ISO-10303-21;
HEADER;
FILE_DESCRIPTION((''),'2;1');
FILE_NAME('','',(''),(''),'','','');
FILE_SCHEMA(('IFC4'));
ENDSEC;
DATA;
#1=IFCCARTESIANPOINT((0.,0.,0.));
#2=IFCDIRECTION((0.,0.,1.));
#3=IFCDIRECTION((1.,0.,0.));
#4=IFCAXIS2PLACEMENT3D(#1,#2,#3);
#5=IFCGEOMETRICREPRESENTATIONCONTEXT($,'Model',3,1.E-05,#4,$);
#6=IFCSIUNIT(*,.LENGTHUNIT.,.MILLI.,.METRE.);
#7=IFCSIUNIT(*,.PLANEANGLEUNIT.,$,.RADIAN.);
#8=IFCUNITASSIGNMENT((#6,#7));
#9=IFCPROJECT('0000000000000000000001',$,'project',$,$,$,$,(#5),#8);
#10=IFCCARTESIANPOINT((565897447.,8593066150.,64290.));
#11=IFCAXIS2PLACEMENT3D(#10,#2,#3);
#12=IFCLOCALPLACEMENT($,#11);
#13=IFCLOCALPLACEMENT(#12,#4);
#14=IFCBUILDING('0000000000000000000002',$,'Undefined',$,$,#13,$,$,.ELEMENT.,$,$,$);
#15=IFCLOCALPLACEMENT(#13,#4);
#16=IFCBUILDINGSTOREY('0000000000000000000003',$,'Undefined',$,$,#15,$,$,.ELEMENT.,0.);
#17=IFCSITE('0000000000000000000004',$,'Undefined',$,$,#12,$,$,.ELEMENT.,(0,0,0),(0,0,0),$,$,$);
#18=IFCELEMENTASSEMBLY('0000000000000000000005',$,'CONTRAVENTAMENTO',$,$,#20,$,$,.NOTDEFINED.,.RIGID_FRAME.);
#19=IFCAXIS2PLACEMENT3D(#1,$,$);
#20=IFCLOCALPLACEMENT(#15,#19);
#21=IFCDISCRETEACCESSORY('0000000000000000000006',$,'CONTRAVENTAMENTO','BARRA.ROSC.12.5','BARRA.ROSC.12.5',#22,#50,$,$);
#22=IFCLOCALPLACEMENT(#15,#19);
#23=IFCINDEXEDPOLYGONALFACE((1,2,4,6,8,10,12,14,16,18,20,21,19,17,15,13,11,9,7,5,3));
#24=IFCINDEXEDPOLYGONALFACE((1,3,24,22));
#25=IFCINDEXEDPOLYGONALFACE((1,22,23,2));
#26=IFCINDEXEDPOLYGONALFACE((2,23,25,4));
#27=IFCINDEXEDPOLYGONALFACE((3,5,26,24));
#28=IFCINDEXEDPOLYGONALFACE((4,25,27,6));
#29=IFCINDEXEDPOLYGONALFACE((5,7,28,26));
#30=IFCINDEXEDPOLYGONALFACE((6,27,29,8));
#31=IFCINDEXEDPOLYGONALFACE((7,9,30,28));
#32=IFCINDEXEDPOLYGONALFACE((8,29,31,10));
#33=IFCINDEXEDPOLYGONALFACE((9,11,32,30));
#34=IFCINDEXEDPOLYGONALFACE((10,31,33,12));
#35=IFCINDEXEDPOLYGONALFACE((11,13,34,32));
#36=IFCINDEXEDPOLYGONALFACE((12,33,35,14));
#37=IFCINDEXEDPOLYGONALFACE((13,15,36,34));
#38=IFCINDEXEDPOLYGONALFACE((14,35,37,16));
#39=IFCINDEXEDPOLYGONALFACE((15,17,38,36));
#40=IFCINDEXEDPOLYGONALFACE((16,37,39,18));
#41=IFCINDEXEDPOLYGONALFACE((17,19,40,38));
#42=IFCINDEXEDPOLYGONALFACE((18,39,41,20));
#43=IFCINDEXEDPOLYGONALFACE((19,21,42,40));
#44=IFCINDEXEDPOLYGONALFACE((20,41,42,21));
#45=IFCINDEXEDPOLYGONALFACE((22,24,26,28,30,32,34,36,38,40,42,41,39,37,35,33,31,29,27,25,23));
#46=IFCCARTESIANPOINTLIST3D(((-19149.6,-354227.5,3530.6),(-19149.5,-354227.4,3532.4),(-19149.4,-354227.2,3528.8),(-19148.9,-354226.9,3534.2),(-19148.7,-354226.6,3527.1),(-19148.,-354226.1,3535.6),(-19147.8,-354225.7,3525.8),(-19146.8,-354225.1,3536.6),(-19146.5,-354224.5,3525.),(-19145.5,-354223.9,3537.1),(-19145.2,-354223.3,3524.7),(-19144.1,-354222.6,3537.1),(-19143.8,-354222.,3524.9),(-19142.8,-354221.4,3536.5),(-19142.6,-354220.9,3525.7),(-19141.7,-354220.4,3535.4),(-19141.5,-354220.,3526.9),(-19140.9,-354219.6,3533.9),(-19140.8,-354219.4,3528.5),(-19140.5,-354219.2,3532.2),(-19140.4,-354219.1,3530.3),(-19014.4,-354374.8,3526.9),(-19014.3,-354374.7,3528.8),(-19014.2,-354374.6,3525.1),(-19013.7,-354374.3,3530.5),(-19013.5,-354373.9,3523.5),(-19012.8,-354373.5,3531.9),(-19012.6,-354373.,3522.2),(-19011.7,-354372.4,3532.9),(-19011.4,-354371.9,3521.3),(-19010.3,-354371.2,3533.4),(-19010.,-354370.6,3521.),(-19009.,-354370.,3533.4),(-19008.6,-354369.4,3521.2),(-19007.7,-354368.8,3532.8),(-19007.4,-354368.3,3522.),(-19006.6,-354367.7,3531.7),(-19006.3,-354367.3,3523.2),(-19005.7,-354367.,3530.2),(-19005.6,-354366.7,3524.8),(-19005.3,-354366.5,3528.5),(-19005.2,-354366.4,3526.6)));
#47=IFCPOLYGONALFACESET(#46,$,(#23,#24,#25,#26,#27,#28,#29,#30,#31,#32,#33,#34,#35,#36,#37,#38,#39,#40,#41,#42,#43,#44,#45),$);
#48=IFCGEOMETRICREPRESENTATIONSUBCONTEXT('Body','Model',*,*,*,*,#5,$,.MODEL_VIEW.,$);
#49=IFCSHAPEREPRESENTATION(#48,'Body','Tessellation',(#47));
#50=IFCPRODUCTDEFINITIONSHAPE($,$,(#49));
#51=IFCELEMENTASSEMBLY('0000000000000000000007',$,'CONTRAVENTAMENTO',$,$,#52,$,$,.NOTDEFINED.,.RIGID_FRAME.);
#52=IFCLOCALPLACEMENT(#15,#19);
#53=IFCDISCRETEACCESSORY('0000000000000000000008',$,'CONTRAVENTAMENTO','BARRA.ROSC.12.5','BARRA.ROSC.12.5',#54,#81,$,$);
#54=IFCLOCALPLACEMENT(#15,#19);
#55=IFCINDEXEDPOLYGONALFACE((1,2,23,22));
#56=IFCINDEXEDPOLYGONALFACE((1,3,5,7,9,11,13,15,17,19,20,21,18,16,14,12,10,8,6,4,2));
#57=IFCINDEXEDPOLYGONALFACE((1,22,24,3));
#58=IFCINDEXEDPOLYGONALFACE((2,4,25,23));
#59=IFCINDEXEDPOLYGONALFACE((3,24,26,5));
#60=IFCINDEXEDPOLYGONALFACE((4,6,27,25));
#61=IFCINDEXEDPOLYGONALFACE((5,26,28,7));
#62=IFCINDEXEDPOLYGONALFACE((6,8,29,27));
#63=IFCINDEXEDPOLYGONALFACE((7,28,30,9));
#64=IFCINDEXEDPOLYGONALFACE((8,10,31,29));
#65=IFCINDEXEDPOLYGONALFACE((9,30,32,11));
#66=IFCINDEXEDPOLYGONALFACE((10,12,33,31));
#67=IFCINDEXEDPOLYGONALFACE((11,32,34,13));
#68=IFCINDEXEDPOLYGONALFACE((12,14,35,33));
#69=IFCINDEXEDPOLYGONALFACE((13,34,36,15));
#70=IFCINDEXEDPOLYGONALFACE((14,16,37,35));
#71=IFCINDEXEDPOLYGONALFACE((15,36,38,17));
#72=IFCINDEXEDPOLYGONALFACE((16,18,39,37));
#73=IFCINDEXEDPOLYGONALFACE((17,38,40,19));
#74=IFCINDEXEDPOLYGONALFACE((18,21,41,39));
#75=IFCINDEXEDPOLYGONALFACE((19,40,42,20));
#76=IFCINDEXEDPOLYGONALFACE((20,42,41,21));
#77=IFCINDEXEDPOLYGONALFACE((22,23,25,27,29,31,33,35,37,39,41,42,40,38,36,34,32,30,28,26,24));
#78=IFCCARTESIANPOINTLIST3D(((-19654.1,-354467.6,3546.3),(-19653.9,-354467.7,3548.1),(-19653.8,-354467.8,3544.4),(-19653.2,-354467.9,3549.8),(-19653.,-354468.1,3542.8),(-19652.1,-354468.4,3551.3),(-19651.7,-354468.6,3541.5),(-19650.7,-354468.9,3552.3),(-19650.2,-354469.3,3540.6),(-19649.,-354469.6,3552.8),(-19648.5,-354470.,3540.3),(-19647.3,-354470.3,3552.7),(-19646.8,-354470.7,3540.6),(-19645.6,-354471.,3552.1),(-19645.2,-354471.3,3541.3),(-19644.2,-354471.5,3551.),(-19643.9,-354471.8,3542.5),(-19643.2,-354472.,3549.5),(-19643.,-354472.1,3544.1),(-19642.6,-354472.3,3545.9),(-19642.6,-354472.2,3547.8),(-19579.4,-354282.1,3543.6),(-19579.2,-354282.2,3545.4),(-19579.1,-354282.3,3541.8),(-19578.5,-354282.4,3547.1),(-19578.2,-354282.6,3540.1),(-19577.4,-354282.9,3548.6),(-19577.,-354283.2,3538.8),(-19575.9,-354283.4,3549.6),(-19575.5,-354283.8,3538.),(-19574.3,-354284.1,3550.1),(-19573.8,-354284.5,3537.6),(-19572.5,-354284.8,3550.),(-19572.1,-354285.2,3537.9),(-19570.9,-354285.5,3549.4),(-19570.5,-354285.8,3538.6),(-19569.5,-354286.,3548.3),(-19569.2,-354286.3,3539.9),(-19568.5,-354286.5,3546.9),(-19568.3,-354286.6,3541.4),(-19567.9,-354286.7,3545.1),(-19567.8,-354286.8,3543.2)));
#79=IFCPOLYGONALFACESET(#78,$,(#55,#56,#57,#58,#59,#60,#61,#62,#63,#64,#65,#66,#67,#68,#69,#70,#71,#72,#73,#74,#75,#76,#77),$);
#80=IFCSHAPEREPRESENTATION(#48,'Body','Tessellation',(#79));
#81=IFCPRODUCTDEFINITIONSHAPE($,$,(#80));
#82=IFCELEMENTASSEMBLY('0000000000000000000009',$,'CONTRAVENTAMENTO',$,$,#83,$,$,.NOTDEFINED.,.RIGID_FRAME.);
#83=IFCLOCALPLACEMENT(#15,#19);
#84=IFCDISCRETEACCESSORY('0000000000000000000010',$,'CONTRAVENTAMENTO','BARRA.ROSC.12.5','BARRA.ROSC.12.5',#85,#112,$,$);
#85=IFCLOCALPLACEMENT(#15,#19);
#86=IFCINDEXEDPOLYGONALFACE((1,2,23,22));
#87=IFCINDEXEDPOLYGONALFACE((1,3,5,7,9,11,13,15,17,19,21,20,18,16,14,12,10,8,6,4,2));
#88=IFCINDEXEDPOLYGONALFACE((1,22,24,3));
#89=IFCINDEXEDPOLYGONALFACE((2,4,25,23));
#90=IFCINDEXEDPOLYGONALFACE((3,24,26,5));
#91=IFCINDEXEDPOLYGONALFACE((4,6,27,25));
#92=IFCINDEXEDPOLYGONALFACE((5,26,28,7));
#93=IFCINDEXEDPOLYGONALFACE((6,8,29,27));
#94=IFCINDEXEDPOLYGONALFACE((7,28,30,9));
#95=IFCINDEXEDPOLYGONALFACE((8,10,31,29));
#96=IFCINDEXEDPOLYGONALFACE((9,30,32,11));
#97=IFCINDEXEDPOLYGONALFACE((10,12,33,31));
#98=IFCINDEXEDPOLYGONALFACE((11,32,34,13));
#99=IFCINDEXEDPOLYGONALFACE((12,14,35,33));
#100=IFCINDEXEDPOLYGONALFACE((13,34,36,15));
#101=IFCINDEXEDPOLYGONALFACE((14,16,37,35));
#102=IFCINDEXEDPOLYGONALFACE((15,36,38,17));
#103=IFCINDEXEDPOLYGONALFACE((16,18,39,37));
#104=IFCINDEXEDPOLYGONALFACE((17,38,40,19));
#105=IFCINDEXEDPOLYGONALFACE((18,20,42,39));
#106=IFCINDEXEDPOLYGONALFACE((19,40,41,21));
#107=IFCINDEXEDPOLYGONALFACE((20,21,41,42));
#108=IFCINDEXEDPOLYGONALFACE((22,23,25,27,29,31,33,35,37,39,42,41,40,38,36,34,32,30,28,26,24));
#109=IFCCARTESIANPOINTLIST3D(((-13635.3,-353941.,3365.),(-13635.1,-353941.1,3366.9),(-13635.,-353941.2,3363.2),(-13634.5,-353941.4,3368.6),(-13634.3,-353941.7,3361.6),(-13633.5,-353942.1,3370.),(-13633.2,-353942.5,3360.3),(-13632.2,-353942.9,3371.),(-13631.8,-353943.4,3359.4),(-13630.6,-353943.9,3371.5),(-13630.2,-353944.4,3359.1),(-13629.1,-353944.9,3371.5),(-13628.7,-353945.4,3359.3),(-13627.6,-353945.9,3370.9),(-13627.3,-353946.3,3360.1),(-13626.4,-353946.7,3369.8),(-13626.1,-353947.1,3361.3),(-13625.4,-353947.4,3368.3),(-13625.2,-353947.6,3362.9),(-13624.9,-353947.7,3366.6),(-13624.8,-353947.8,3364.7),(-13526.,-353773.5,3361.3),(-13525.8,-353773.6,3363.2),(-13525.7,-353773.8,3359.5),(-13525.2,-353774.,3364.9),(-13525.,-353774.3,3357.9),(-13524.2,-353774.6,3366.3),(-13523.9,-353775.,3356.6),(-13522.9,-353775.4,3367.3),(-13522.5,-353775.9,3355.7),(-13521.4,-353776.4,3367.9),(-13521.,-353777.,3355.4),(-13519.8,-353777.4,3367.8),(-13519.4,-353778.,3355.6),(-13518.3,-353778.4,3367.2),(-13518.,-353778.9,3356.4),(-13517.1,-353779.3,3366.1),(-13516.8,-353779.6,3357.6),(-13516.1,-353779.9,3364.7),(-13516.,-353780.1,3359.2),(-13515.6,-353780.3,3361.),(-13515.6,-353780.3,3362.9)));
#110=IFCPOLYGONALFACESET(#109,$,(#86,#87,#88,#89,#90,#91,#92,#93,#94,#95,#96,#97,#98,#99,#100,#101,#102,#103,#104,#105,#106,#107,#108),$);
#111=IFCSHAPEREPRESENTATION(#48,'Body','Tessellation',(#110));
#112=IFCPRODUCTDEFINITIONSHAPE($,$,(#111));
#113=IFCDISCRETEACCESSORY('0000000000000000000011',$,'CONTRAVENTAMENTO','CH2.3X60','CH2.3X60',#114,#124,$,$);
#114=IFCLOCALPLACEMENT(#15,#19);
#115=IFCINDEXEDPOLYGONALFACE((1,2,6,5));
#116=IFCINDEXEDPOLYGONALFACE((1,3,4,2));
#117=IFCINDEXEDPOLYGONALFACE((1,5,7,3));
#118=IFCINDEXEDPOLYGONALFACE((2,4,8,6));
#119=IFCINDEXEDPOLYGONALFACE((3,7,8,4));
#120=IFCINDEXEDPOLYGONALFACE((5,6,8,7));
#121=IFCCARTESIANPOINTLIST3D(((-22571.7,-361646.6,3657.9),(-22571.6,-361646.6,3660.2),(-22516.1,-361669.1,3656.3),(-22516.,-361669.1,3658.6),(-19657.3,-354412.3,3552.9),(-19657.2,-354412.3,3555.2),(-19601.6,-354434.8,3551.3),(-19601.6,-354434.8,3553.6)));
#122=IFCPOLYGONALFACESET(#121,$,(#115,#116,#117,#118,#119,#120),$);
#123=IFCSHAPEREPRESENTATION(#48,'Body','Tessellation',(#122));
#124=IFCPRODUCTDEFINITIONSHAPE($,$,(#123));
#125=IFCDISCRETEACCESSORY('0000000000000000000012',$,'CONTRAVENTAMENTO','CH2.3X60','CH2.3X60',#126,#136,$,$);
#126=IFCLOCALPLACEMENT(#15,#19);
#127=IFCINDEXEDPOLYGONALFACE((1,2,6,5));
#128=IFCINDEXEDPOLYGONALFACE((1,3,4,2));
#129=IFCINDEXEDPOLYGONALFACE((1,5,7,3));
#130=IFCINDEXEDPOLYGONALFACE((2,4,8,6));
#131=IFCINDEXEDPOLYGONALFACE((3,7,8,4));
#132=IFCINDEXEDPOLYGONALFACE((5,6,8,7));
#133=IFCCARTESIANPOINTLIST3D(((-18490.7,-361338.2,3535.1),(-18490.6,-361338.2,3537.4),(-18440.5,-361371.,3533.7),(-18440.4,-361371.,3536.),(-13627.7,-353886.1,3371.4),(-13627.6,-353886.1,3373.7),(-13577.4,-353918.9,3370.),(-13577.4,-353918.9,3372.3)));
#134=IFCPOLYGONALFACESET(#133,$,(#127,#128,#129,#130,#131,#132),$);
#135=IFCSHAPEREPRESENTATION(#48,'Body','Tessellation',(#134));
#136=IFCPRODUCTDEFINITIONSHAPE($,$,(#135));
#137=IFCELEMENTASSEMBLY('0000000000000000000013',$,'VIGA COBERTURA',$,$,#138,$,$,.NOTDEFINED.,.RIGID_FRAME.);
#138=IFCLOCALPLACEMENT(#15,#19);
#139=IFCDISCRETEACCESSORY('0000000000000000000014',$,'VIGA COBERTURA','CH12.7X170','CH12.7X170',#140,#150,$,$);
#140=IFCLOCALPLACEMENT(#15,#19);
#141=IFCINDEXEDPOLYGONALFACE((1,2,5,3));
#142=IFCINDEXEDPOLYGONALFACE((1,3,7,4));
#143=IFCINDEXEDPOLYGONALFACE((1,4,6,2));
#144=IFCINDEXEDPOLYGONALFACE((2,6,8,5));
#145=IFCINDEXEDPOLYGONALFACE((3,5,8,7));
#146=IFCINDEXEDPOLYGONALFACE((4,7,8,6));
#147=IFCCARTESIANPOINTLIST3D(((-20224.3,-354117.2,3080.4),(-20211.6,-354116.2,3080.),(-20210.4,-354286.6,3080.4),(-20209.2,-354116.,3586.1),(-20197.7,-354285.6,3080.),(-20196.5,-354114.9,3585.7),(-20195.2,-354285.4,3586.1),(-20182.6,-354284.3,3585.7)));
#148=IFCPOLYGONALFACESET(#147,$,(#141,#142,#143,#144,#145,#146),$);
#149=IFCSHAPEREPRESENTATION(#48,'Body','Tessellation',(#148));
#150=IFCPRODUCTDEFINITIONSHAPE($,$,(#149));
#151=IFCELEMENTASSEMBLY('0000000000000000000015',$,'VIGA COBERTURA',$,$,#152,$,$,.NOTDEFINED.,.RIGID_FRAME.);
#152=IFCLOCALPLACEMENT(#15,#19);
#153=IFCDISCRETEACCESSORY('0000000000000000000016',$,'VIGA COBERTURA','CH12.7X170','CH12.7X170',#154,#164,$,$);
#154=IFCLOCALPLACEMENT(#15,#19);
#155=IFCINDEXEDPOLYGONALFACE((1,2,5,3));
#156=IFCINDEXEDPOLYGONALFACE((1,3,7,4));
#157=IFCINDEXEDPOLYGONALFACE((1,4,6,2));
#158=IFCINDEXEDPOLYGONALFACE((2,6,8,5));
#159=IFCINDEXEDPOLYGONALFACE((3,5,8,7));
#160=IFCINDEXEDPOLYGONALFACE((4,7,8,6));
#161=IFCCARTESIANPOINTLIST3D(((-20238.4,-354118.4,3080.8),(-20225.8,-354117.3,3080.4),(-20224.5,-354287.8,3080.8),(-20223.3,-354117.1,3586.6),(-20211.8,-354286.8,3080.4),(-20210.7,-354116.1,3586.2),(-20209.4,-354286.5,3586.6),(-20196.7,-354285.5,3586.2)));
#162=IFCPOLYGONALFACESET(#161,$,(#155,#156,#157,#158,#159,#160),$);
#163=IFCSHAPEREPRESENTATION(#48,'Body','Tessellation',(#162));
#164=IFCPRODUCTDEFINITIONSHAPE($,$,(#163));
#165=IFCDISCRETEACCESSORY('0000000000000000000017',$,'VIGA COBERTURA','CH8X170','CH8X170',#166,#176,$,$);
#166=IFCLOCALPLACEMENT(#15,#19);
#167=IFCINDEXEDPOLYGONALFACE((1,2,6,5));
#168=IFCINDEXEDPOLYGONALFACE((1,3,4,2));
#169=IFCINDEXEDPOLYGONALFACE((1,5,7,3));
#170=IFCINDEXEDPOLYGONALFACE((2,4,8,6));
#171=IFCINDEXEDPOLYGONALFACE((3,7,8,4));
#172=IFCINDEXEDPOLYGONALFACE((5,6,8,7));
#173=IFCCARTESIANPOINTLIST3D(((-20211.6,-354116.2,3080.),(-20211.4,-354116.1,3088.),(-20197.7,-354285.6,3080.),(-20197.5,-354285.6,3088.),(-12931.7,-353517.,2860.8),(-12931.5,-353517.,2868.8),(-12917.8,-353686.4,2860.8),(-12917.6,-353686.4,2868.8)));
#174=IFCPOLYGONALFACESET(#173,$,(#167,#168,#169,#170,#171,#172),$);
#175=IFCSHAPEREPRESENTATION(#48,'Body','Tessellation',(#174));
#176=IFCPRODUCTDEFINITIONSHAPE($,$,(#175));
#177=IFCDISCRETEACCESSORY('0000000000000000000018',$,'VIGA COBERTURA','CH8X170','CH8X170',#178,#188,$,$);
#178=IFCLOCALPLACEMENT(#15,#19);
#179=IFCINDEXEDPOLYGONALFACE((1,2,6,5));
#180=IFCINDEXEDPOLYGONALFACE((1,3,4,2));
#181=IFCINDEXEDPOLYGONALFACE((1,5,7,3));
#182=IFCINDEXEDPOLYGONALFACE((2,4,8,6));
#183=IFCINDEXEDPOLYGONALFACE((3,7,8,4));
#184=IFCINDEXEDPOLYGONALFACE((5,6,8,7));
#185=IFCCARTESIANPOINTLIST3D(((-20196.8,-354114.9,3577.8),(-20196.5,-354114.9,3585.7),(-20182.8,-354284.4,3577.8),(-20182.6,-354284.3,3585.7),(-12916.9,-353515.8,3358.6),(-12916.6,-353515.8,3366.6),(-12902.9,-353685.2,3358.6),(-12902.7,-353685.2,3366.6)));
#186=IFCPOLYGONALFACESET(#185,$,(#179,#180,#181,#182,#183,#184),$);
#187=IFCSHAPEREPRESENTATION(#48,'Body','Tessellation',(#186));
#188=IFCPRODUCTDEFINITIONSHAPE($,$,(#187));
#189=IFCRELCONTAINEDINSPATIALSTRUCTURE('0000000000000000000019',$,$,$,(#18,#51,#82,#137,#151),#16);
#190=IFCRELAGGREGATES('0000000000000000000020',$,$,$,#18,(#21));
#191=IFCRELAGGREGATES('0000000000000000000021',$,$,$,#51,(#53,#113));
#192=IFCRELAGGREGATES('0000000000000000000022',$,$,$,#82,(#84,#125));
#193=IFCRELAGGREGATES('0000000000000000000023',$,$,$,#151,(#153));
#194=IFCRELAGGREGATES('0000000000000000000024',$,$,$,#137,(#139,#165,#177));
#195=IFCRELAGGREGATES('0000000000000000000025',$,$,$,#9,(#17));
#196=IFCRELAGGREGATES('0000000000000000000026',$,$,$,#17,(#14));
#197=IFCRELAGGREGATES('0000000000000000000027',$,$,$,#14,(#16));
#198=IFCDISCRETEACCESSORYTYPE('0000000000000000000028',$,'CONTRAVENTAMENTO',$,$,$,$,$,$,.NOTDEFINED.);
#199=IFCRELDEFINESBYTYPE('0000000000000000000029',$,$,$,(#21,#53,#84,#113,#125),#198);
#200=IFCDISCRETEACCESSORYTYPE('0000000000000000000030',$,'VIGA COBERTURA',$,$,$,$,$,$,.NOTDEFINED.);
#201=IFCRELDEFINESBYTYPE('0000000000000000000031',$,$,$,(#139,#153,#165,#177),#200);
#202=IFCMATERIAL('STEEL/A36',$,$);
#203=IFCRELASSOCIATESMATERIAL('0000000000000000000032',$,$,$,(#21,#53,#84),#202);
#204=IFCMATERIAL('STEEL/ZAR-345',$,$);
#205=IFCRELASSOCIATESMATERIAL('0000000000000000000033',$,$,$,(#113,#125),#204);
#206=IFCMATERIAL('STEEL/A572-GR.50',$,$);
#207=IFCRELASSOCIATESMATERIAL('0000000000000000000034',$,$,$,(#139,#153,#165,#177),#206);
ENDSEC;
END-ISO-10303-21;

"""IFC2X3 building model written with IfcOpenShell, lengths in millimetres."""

from ifc_helpers import new_model, si_unit, frame, origin_with_axes, origin_2d_with_axis, place, context, subcontext, project, spatial, polyline, rectangle, circle, outline, extrude, material, type_object, element, aggregate, save


model = new_model("IFC2X3")

# Units and contexts
model_context = context("Model", 3, precision=1e-05, world=origin_with_axes())
body_context = subcontext(model_context, "Body", "Model", "MODEL_VIEW")
ifc_project = project(units=[si_unit("LENGTHUNIT", "METRE", prefix="MILLI"), si_unit("PLANEANGLEUNIT", "RADIAN")], contexts=[model_context])

# Site, building, storey
site_placement = place(None, frame((565897447.0, 8593066150.0, 64290.0), z_axis=(0.0, 0.0, 1.0), x_axis=(1.0, 0.0, 0.0)))
site = spatial("IfcSite", under=ifc_project, at=site_placement, Name="Undefined", CompositionType="ELEMENT", RefLatitude=(0, 0, 0), RefLongitude=(0, 0, 0))
building_placement = place(site_placement, origin_with_axes())
building = spatial("IfcBuilding", under=site, at=building_placement, Name="Undefined", CompositionType="ELEMENT")
storey_placement = place(building_placement, origin_with_axes())
storey = spatial("IfcBuildingStorey", under=building, at=storey_placement, Name="Undefined", CompositionType="ELEMENT", Elevation=0.0)

# Shared definitions
ifc_material_1 = material(Name="STEEL/A36")

# Element assemblies, discrete accessories
assembly_1_placement = place(storey_placement, origin_with_axes())
assembly_1 = element("IfcElementAssembly", 1, at=assembly_1_placement, inside=storey, Name="CONTRAVENTAMENTO", AssemblyPlace="NOTDEFINED", PredefinedType="RIGID_FRAME")
discrete_accessory_type_1 = type_object("IfcDiscreteAccessoryType", Name="CONTRAVENTAMENTO")
discrete_accessory_1_placement = place(assembly_1_placement, frame((-19145.0, -354223.3, 3530.9), z_axis=(-0.736334, -0.676203, 0.02368), x_axis=(0.675958, -0.736711, -0.018398)))
discrete_accessory_1 = element("IfcDiscreteAccessory", 2, at=discrete_accessory_1_placement, type_object=discrete_accessory_type_1, material=ifc_material_1, Name="CONTRAVENTAMENTO", Description="BARRA.ROSC.12.5", ObjectType="BARRA.ROSC.12.5", context=body_context, shape_type="SweptSolid", body=[
    extrude(circle(Radius=6.2, at=origin_2d_with_axis()), frame((200.0, 0.0, 0.0), z_axis=(-1.0, 0.0, 0.0), x_axis=(0.0, -1.0, 0.0)), (0.0, 0.0, 1.0), 200.0),
])
aggregate(assembly_1, [discrete_accessory_1])
assembly_2_placement = place(storey_placement, origin_with_axes())
assembly_2 = element("IfcElementAssembly", 3, at=assembly_2_placement, inside=storey, Name="CONTRAVENTAMENTO", AssemblyPlace="NOTDEFINED", PredefinedType="RIGID_FRAME")
discrete_accessory_2_placement = place(assembly_2_placement, frame((-19573.6, -354284.5, 3543.9), z_axis=(-0.92709, 0.373879, 0.026799), x_axis=(-0.373645, -0.927474, 0.013454)))
discrete_accessory_2 = element("IfcDiscreteAccessory", 4, at=discrete_accessory_2_placement, type_object=discrete_accessory_type_1, material=ifc_material_1, Name="CONTRAVENTAMENTO", Description="BARRA.ROSC.12.5", ObjectType="BARRA.ROSC.12.5", context=body_context, shape_type="SweptSolid", body=[
    extrude(circle(Radius=6.2, at=origin_2d_with_axis()), frame((200.0, 0.0, 0.0), z_axis=(-1.0, 0.0, 0.0), x_axis=(0.0, -1.0, 0.0)), (0.0, 0.0, 1.0), 200.0),
])
assembly_3_placement = place(storey_placement, origin_with_axes())
assembly_3 = element("IfcElementAssembly", 5, at=assembly_3_placement, inside=storey, Name="CONTRAVENTAMENTO", AssemblyPlace="NOTDEFINED", PredefinedType="RIGID_FRAME")
discrete_accessory_3_placement = place(assembly_3_placement, frame((-13520.8, -353776.9, 3361.7), z_axis=(-0.836984, 0.546715, 0.02368), x_axis=(-0.546411, -0.837315, 0.018398)))
discrete_accessory_3 = element("IfcDiscreteAccessory", 6, at=discrete_accessory_3_placement, type_object=discrete_accessory_type_1, material=ifc_material_1, Name="CONTRAVENTAMENTO", Description="BARRA.ROSC.12.5", ObjectType="BARRA.ROSC.12.5", context=body_context, shape_type="SweptSolid", body=[
    extrude(circle(Radius=6.2, at=origin_2d_with_axis()), frame((200.0, 0.0, 0.0), z_axis=(-1.0, 0.0, 0.0), x_axis=(0.0, -1.0, 0.0)), (0.0, 0.0, 1.0), 200.0),
])

# Discrete accessories
ifc_material_2 = material(Name="STEEL/ZAR-345")
discrete_accessory_4_placement = place(assembly_2_placement, frame((-19629.4, -354423.6, 3553.3), z_axis=(-0.029885, -0.00246, -0.99955), x_axis=(-0.373645, -0.927474, 0.013454)))
discrete_accessory_4 = element("IfcDiscreteAccessory", 7, at=discrete_accessory_4_placement, type_object=discrete_accessory_type_1, material=ifc_material_2, Name="CONTRAVENTAMENTO", Description="CH2.3X60", ObjectType="CH2.3X60", context=body_context, shape_type="SweptSolid", body=[
    extrude(outline(polyline([(0.0, 30.0), (7800.0, 30.0), (7800.0, -30.0), (0.0, -30.0), (0.0, 30.0)])), frame((0.0, 0.0, -1.1), z_axis=(0.0, 0.0, 1.0), x_axis=(1.0, 0.0, 0.0)), (0.0, 0.0, 1.0), 2.3),
])
aggregate(assembly_2, [discrete_accessory_2, discrete_accessory_4])
discrete_accessory_5_placement = place(assembly_3_placement, frame((-13602.5, -353902.5, 3371.8), z_axis=(-0.029885, -0.00246, -0.99955), x_axis=(-0.546411, -0.837315, 0.018398)))
discrete_accessory_5 = element("IfcDiscreteAccessory", 8, at=discrete_accessory_5_placement, type_object=discrete_accessory_type_1, material=ifc_material_2, Name="CONTRAVENTAMENTO", Description="CH2.3X60", ObjectType="CH2.3X60", context=body_context, shape_type="SweptSolid", body=[
    extrude(outline(polyline([(0.0, 30.0), (8900.0, 30.0), (8900.0, -30.0), (0.0, -30.0), (0.0, 30.0)])), frame((0.0, 0.0, -1.1), z_axis=(0.0, 0.0, 1.0), x_axis=(1.0, 0.0, 0.0)), (0.0, 0.0, 1.0), 2.3),
])
aggregate(assembly_3, [discrete_accessory_3, discrete_accessory_5])

# Element assemblies, discrete accessories
assembly_4_placement = place(storey_placement, origin_with_axes())
assembly_4 = element("IfcElementAssembly", 9, at=assembly_4_placement, inside=storey, Name="VIGA COBERTURA", AssemblyPlace="NOTDEFINED", PredefinedType="RIGID_FRAME")
ifc_material_3 = material(Name="STEEL/A572-GR.50")
discrete_accessory_type_2 = type_object("IfcDiscreteAccessoryType", Name="VIGA COBERTURA")
discrete_accessory_6_placement = place(assembly_4_placement, frame((-20195.9, -354200.1, 3585.9), z_axis=(-0.082025, 0.99663, 0.0), x_axis=(-0.029885, -0.00246, -0.99955)))
discrete_accessory_6 = element("IfcDiscreteAccessory", 10, at=discrete_accessory_6_placement, type_object=discrete_accessory_type_2, material=ifc_material_3, Name="VIGA COBERTURA", Description="CH12.7X170", ObjectType="CH12.7X170", context=body_context, shape_type="SweptSolid", body=[
    extrude(rectangle(XDim=12.7, YDim=170.0, at=origin_2d_with_axis()), frame((506.0, 0.0, 0.0), z_axis=(-1.0, 0.0, 0.0), x_axis=(0.0, -1.0, 0.0)), (0.0, 0.0, 1.0), 506.0),
])
assembly_5_placement = place(storey_placement, origin_with_axes())
assembly_5 = element("IfcElementAssembly", 11, at=assembly_5_placement, inside=storey, Name="VIGA COBERTURA", AssemblyPlace="NOTDEFINED", PredefinedType="RIGID_FRAME")
discrete_accessory_7_placement = place(assembly_5_placement, frame((-20210.0, -354201.3, 3586.4), z_axis=(-0.082025, 0.99663, 0.0), x_axis=(-0.029885, -0.00246, -0.99955)))
discrete_accessory_7 = element("IfcDiscreteAccessory", 12, at=discrete_accessory_7_placement, type_object=discrete_accessory_type_2, material=ifc_material_3, Name="VIGA COBERTURA", Description="CH12.7X170", ObjectType="CH12.7X170", context=body_context, shape_type="SweptSolid", body=[
    extrude(rectangle(XDim=12.7, YDim=170.0, at=origin_2d_with_axis()), frame((506.0, 0.0, 0.0), z_axis=(-1.0, 0.0, 0.0), x_axis=(0.0, -1.0, 0.0)), (0.0, 0.0, 1.0), 506.0),
])

# Discrete accessories
discrete_accessory_8_placement = place(assembly_4_placement, frame((-20204.6, -354200.9, 3084.0), z_axis=(-0.029885, -0.00246, -0.99955), x_axis=(0.996182, 0.081989, -0.029987)))
discrete_accessory_8 = element("IfcDiscreteAccessory", 13, at=discrete_accessory_8_placement, type_object=discrete_accessory_type_2, material=ifc_material_3, Name="VIGA COBERTURA", Description="CH8X170", ObjectType="CH8X170", context=body_context, shape_type="SweptSolid", body=[
    extrude(outline(polyline([(0.0, -85.0), (0.0, 85.0), (7307.8, 85.0), (7307.8, -85.0), (0.0, -85.0)])), frame((0.0, 0.0, -4.0), z_axis=(0.0, 0.0, 1.0), x_axis=(1.0, 0.0, 0.0)), (0.0, 0.0, 1.0), 8.0),
])
aggregate(assembly_5, [discrete_accessory_7])
discrete_accessory_9_placement = place(assembly_4_placement, frame((-20189.7, -354199.6, 3581.7), z_axis=(-0.029885, -0.00246, -0.99955), x_axis=(0.996182, 0.081989, -0.029987)))
discrete_accessory_9 = element("IfcDiscreteAccessory", 14, at=discrete_accessory_9_placement, type_object=discrete_accessory_type_2, material=ifc_material_3, Name="VIGA COBERTURA", Description="CH8X170", ObjectType="CH8X170", context=body_context, shape_type="SweptSolid", body=[
    extrude(outline(polyline([(0.0, -85.0), (0.0, 85.0), (7307.8, 85.0), (7307.8, -85.0), (0.0, -85.0)])), frame((0.0, 0.0, -4.0), z_axis=(0.0, 0.0, 1.0), x_axis=(1.0, 0.0, 0.0)), (0.0, 0.0, 1.0), 8.0),
])
aggregate(assembly_4, [discrete_accessory_6, discrete_accessory_8, discrete_accessory_9])

save(model, "model.ifc")
